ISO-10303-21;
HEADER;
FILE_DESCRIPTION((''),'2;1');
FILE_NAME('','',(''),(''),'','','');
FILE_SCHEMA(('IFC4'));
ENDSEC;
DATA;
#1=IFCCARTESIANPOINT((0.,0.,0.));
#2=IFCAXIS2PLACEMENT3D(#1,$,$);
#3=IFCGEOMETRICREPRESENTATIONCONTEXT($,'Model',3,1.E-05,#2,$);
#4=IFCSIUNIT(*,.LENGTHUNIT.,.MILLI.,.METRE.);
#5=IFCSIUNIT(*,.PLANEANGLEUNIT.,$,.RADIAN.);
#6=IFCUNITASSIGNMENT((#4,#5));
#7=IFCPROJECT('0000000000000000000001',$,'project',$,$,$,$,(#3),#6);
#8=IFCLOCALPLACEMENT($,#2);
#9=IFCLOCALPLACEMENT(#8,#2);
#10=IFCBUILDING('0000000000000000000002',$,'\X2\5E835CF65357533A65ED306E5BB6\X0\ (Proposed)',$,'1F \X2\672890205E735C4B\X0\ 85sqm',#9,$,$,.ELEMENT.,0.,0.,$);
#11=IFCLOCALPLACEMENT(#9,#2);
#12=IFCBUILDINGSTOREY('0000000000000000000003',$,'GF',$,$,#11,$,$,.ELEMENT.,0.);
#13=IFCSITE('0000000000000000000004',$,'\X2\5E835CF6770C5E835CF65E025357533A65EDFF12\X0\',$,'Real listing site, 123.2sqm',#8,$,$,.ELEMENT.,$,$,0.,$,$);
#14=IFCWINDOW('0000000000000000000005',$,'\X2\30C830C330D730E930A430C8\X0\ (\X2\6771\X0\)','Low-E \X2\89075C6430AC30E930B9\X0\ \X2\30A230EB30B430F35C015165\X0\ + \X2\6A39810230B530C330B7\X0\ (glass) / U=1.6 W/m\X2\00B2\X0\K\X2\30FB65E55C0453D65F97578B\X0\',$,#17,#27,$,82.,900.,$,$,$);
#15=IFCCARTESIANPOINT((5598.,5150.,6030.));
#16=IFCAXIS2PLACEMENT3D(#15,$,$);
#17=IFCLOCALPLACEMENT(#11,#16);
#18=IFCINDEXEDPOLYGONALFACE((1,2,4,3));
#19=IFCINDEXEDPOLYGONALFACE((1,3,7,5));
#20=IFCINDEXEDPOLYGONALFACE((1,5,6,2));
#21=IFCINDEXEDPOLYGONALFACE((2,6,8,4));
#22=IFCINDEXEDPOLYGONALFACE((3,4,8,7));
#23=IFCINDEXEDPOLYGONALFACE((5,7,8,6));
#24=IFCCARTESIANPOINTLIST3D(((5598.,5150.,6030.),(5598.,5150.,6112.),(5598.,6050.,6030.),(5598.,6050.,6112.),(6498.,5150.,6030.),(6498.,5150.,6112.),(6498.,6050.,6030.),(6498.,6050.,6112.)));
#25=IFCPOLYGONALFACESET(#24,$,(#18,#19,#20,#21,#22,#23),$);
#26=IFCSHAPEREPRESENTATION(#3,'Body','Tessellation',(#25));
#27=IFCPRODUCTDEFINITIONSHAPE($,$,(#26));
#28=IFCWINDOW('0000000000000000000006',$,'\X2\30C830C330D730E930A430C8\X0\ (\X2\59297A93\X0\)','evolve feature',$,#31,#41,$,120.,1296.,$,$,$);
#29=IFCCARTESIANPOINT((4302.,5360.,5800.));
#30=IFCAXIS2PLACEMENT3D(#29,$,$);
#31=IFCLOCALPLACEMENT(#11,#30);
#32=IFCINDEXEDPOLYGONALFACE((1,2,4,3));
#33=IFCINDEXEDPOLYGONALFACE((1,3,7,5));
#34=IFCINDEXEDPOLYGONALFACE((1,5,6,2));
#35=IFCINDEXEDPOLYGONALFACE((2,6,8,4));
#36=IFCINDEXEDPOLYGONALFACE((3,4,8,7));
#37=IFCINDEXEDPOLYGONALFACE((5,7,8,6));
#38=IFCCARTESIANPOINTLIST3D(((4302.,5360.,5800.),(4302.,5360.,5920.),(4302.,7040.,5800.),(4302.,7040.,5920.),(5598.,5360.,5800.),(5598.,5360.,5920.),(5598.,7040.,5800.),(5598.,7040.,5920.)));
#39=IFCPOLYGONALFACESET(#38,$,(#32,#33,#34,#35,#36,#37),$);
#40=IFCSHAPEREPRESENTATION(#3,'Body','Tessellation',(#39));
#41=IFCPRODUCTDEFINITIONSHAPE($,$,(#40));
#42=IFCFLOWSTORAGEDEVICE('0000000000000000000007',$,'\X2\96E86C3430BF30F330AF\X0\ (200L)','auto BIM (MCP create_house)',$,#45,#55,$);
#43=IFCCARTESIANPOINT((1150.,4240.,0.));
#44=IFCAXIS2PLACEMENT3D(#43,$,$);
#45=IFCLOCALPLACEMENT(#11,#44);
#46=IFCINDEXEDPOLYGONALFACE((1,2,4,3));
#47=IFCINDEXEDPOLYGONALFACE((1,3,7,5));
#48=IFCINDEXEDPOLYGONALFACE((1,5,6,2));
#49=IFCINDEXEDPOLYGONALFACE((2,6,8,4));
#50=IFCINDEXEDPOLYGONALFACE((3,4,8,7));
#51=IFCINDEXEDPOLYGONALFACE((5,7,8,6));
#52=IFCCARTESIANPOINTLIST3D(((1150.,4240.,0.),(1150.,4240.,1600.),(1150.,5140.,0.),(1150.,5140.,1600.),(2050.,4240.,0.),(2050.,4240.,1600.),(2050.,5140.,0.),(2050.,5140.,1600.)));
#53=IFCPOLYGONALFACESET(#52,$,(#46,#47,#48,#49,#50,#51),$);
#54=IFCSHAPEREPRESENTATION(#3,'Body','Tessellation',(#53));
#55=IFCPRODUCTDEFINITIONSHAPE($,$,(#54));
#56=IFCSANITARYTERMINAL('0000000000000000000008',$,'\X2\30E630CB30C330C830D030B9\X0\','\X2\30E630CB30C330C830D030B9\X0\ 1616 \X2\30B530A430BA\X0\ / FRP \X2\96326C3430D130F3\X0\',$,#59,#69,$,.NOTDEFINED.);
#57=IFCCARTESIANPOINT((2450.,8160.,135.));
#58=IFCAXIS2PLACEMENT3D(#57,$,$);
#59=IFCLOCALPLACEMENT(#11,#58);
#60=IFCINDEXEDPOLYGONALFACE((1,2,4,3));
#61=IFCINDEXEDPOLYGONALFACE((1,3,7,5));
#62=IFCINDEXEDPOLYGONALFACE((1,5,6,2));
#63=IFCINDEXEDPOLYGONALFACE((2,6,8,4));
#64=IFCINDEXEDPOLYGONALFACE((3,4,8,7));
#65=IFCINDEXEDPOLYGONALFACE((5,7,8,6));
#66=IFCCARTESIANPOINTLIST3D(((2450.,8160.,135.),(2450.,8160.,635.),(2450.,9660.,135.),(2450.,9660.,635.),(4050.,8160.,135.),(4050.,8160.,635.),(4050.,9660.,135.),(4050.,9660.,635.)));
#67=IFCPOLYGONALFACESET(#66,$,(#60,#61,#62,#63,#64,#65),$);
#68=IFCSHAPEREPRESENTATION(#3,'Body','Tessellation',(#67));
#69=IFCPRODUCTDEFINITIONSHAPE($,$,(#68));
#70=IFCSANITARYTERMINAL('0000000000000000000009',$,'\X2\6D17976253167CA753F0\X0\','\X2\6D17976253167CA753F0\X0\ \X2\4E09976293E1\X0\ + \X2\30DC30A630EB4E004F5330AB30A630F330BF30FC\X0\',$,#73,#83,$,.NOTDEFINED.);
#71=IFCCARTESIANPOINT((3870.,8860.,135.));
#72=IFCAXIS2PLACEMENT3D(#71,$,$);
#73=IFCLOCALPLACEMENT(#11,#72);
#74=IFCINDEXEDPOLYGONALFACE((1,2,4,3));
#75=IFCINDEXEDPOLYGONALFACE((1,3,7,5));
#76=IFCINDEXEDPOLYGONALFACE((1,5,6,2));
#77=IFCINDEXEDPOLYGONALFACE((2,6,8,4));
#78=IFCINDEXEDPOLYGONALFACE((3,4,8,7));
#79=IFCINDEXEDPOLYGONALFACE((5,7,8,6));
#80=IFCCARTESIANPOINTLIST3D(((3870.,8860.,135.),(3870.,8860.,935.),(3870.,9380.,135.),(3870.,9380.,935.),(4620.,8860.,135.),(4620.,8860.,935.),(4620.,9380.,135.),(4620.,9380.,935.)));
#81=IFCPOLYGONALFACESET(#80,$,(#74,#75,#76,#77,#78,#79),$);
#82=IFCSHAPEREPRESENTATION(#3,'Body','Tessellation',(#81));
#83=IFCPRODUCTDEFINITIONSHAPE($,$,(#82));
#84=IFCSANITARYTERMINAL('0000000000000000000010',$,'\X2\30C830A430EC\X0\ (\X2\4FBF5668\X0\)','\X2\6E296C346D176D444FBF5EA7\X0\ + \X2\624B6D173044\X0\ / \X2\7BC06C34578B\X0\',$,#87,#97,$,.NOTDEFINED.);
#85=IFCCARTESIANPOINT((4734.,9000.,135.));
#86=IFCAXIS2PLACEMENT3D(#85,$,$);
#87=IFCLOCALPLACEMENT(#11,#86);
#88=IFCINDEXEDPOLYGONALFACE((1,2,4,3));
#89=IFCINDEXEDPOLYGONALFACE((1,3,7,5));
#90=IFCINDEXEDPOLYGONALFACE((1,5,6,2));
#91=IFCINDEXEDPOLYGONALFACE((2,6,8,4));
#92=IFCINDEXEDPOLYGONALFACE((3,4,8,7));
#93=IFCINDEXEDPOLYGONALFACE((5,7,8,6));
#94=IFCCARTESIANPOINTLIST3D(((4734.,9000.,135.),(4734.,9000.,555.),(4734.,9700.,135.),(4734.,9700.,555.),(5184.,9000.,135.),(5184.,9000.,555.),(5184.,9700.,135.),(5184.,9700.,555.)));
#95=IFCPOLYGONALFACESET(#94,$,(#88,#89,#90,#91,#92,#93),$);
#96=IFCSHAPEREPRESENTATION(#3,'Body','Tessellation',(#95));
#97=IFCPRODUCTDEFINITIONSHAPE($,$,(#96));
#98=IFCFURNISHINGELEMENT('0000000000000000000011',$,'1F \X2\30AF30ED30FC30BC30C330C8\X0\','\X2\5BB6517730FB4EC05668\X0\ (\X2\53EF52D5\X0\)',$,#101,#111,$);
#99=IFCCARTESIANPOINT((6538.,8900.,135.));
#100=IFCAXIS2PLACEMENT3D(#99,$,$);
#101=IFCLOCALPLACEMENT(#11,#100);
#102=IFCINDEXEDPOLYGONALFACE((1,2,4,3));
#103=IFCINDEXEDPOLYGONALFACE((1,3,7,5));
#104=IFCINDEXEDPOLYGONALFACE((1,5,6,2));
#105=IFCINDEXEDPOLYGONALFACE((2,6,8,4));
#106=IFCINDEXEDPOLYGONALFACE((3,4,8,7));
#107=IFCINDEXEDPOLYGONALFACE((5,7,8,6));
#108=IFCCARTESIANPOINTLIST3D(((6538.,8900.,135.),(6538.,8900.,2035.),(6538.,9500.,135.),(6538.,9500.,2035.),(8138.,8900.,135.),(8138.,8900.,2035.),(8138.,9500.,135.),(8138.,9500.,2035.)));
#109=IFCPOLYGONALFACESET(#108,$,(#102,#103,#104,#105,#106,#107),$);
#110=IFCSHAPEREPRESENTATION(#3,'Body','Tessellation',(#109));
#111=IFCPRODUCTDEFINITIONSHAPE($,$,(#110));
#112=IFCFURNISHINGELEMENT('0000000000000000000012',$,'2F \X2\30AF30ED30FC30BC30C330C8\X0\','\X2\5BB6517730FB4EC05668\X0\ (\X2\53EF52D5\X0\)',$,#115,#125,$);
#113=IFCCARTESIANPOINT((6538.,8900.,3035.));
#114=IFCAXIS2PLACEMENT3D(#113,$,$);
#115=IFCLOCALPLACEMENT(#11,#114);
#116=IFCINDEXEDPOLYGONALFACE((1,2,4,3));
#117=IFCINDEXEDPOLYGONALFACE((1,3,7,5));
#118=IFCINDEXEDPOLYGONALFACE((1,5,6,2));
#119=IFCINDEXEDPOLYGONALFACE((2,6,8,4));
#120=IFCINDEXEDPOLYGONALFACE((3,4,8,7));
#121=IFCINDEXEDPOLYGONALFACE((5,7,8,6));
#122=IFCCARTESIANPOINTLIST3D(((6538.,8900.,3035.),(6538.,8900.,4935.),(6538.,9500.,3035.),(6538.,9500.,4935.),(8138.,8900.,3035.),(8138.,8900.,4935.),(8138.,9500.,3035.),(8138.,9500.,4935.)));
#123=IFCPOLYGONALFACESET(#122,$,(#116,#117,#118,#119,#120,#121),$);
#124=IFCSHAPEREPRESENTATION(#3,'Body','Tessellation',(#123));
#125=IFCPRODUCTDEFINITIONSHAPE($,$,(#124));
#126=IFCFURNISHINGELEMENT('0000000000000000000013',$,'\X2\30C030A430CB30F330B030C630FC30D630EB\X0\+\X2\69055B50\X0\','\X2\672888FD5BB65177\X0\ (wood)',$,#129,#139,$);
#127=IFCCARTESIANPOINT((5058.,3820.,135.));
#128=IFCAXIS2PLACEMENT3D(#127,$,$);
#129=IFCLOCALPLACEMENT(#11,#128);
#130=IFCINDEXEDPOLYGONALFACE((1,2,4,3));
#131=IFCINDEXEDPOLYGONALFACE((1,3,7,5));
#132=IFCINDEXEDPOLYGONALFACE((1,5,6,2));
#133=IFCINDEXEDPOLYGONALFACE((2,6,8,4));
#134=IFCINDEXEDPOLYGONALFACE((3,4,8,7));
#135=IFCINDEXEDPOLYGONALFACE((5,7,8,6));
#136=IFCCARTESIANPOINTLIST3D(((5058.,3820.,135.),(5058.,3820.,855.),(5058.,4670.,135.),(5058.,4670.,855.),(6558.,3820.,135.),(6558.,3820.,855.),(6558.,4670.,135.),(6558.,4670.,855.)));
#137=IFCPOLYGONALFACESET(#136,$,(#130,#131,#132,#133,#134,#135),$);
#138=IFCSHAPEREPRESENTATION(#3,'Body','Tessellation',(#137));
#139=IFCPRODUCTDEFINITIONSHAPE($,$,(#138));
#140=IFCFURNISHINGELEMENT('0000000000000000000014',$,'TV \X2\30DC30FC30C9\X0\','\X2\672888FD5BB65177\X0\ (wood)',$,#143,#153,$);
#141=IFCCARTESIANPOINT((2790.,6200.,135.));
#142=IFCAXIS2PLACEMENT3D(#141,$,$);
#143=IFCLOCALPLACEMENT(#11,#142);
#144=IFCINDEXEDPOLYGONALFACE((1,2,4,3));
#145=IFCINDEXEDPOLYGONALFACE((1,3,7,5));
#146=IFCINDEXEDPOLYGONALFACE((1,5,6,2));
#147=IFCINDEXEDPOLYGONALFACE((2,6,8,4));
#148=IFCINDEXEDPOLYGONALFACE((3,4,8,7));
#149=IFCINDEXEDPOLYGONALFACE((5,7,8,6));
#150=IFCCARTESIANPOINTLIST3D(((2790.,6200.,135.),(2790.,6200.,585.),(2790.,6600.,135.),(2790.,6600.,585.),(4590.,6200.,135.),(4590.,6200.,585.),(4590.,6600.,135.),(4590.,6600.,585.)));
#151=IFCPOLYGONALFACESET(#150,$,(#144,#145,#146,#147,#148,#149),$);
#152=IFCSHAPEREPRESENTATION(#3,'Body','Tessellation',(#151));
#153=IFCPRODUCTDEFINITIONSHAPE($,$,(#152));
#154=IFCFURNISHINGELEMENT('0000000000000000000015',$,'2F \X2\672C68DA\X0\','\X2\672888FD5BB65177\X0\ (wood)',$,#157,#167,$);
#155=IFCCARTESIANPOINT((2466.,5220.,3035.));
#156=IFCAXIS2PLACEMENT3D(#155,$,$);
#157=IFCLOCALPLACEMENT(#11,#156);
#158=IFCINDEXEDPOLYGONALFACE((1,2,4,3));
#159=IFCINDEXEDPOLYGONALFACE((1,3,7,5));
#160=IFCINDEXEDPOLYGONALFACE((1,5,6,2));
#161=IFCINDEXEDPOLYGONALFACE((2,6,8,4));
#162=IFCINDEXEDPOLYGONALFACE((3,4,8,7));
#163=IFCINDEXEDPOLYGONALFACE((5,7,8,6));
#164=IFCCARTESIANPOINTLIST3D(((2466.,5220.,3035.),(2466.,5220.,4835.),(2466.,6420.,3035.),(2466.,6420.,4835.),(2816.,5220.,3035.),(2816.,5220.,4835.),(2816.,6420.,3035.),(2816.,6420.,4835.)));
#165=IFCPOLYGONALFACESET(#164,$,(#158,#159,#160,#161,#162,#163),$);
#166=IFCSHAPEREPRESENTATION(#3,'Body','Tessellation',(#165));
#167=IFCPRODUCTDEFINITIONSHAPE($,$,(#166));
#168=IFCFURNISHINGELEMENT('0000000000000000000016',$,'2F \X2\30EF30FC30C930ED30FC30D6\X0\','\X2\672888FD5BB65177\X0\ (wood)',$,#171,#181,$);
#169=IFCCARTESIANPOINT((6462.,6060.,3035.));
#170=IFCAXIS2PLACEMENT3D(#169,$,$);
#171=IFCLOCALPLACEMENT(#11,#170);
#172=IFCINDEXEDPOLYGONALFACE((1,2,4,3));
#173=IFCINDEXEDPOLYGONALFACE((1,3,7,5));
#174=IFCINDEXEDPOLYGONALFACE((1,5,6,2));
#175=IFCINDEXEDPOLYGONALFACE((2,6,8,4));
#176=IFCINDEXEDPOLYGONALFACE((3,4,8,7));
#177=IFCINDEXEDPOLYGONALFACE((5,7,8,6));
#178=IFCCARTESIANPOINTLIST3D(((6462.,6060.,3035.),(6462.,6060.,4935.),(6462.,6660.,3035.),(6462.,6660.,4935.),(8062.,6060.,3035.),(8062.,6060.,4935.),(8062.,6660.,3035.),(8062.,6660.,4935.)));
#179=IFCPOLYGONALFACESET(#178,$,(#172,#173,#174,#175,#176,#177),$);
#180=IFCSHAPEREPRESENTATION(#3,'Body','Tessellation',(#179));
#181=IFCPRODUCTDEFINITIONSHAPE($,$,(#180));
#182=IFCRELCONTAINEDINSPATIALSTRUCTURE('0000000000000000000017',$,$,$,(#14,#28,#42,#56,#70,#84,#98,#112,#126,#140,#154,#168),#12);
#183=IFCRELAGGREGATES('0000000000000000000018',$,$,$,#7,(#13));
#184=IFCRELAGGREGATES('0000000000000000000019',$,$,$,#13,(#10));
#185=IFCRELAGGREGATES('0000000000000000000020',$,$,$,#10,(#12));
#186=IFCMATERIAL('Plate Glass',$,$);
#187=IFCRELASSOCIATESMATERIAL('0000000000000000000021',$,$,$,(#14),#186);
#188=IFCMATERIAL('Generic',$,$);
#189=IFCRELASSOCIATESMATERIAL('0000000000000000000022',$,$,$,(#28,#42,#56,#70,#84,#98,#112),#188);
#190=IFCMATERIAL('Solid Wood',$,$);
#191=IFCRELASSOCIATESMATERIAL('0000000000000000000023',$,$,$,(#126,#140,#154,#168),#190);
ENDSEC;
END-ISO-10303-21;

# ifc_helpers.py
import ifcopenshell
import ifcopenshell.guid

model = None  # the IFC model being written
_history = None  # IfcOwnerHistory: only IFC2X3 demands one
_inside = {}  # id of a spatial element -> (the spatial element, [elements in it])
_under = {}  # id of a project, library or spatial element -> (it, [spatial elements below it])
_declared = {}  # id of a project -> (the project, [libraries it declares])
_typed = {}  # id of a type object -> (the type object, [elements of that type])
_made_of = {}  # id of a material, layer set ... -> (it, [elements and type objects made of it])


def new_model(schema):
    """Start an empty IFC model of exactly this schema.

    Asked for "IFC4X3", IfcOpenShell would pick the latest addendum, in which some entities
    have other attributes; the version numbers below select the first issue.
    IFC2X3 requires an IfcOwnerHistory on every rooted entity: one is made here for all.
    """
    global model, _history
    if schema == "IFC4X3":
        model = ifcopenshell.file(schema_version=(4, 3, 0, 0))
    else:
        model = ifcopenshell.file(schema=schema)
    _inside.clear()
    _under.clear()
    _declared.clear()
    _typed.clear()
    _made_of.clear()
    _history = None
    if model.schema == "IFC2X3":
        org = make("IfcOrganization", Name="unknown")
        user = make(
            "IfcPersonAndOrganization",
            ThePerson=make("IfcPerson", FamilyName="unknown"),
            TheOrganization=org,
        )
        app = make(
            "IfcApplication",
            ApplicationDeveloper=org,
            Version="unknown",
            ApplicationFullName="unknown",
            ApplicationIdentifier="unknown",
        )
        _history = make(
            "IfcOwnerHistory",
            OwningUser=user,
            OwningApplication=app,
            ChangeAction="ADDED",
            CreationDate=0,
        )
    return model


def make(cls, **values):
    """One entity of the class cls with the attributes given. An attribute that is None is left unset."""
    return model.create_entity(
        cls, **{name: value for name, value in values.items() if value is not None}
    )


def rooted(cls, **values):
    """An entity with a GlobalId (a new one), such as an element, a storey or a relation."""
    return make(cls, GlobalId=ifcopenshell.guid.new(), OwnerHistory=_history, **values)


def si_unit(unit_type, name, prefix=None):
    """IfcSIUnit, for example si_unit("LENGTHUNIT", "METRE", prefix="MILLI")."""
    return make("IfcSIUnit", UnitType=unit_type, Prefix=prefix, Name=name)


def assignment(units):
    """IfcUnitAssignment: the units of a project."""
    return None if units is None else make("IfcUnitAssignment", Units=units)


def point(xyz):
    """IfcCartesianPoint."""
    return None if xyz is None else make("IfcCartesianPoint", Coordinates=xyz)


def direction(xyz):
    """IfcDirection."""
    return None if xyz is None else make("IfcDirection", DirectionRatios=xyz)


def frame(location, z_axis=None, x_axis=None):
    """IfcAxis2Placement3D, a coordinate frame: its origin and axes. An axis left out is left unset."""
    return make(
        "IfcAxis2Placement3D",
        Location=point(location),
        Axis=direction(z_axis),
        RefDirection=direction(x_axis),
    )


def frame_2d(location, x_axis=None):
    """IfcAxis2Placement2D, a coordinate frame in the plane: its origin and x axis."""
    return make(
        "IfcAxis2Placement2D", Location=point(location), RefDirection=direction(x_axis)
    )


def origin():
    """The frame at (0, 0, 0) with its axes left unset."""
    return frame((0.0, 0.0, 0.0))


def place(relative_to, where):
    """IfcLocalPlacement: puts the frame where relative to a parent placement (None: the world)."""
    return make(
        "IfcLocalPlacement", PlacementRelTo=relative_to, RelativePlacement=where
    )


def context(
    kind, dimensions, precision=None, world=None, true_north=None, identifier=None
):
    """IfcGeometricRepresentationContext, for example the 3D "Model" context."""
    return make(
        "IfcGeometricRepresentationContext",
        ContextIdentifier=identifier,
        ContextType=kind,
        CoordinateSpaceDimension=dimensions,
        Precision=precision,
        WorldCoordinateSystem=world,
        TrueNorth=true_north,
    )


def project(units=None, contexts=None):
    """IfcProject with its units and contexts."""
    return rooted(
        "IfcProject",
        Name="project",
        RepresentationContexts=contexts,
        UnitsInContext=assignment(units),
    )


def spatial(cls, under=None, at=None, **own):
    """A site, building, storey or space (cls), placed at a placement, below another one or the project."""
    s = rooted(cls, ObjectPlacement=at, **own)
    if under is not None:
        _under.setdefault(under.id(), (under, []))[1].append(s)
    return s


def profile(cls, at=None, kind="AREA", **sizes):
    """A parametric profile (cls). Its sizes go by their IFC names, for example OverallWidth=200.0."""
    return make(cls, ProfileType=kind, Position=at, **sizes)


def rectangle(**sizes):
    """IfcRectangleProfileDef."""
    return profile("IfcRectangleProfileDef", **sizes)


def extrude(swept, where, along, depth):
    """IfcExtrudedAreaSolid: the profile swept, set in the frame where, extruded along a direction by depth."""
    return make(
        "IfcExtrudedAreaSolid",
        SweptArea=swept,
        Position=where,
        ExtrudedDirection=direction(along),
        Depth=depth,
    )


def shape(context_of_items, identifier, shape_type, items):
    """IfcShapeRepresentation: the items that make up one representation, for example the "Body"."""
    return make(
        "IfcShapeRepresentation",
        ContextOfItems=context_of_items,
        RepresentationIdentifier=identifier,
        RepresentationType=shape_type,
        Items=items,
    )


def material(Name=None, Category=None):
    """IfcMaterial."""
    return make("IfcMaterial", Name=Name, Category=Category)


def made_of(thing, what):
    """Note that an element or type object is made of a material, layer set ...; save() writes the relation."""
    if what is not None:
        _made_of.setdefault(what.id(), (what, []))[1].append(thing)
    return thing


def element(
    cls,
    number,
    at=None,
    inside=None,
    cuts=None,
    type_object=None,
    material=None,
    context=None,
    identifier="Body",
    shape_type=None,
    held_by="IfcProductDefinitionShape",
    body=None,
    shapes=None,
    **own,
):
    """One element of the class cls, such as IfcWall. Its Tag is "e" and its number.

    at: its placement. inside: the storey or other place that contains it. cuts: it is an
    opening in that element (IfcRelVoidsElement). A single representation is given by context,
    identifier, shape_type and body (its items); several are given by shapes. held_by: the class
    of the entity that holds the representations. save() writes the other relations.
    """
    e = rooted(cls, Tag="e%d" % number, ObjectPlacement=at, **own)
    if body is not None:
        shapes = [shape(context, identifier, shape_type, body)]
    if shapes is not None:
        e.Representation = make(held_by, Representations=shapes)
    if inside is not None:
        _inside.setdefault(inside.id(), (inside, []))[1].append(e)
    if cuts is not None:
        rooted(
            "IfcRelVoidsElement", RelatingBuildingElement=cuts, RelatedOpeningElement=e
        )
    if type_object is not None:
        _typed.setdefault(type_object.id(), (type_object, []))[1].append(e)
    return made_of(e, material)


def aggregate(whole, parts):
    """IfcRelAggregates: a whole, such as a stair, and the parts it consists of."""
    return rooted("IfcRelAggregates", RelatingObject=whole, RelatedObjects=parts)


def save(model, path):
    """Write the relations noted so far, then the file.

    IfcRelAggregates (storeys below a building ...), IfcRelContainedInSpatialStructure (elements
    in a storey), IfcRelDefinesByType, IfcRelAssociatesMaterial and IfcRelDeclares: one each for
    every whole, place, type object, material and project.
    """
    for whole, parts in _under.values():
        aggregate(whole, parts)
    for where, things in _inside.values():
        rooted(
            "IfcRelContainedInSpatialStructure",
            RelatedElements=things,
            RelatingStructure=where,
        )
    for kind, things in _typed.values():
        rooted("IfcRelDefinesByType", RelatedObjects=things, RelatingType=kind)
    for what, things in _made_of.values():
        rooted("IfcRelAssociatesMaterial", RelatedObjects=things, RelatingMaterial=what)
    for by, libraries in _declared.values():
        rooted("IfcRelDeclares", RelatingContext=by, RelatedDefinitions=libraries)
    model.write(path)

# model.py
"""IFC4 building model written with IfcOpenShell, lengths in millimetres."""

from ifc_helpers import new_model, si_unit, frame, frame_2d, origin, place, context, project, spatial, rectangle, extrude, material, element, save


model = new_model("IFC4")

# Units and contexts
model_context = context("Model", 3, precision=1e-05, world=origin())
ifc_project = project(units=[si_unit("LENGTHUNIT", "METRE", prefix="MILLI"), si_unit("PLANEANGLEUNIT", "RADIAN")], contexts=[model_context])

# Site, building, storey
site_placement = place(None, origin())
site = spatial("IfcSite", under=ifc_project, at=site_placement, Name="広島県広島市南区旭２", ObjectType="Real listing site, 123.2sqm", CompositionType="ELEMENT", RefElevation=0.0)
building_placement = place(site_placement, origin())
building = spatial("IfcBuilding", under=site, at=building_placement, Name="広島南区旭の家 (Proposed)", ObjectType="1F 木造平屋 85sqm", CompositionType="ELEMENT", ElevationOfRefHeight=0.0, ElevationOfTerrain=0.0)
storey_placement = place(building_placement, origin())
storey = spatial("IfcBuildingStorey", under=building, at=storey_placement, Name="GF", CompositionType="ELEMENT", Elevation=0.0)

# Shared definitions
ifc_material_1 = material(Name="Solid Wood")
ifc_material_2 = material(Name="Plate Glass")

# Windows
window_1_placement = place(storey_placement, frame((5598.0, 5150.0, 6030.0)))
element("IfcWindow", 1, at=window_1_placement, inside=storey, material=ifc_material_2, Name="トップライト (東)", Description="Low-E 複層ガラス アルゴン封入 + 樹脂サッシ (glass) / U=1.6 W/m²K・日射取得型", OverallHeight=82.0, OverallWidth=900.0, context=model_context, shape_type="SweptSolid", body=[
    extrude(rectangle(XDim=900.0, YDim=900.0, at=frame_2d((450.0, 450.0))), frame((5598.0, 5150.0, 6030.0)), (0.0, 0.0, 1.0), 82.0),
])
ifc_material_3 = material(Name="Generic")
window_2_placement = place(storey_placement, frame((4302.0, 5360.0, 5800.0)))
element("IfcWindow", 2, at=window_2_placement, inside=storey, material=ifc_material_3, Name="トップライト (天窓)", Description="evolve feature", OverallHeight=120.0, OverallWidth=1296.0, context=model_context, shape_type="SweptSolid", body=[
    extrude(rectangle(XDim=1296.0, YDim=1680.0, at=frame_2d((648.0, 840.0))), frame((4302.0, 5360.0, 5800.0)), (0.0, 0.0, 1.0), 120.0),
])

# Flow storage device
flow_storage_device_placement = place(storey_placement, frame((1150.0, 4240.0, 0.0)))
element("IfcFlowStorageDevice", 3, at=flow_storage_device_placement, inside=storey, material=ifc_material_3, Name="雨水タンク (200L)", Description="auto BIM (MCP create_house)", context=model_context, shape_type="SweptSolid", body=[
    extrude(rectangle(XDim=900.0, YDim=900.0, at=frame_2d((450.0, 450.0))), frame((1150.0, 4240.0, 0.0)), (0.0, 0.0, 1.0), 1600.0),
])

# Sanitary terminals
sanitary_terminal_1_placement = place(storey_placement, frame((2450.0, 8160.0, 135.0)))
element("IfcSanitaryTerminal", 4, at=sanitary_terminal_1_placement, inside=storey, material=ifc_material_3, Name="ユニットバス", Description="ユニットバス 1616 サイズ / FRP 防水パン", PredefinedType="NOTDEFINED", context=model_context, shape_type="SweptSolid", body=[
    extrude(rectangle(XDim=1600.0, YDim=1500.0, at=frame_2d((800.0, 750.0))), frame((2450.0, 8160.0, 135.0)), (0.0, 0.0, 1.0), 500.0),
])
sanitary_terminal_2_placement = place(storey_placement, frame((3870.0, 8860.0, 135.0)))
element("IfcSanitaryTerminal", 5, at=sanitary_terminal_2_placement, inside=storey, material=ifc_material_3, Name="洗面化粧台", Description="洗面化粧台 三面鏡 + ボウル一体カウンター", PredefinedType="NOTDEFINED", context=model_context, shape_type="SweptSolid", body=[
    extrude(rectangle(XDim=750.0, YDim=520.0, at=frame_2d((375.0, 260.0))), frame((3870.0, 8860.0, 135.0)), (0.0, 0.0, 1.0), 800.0),
])
sanitary_terminal_3_placement = place(storey_placement, frame((4734.0, 9000.0, 135.0)))
element("IfcSanitaryTerminal", 6, at=sanitary_terminal_3_placement, inside=storey, material=ifc_material_3, Name="トイレ (便器)", Description="温水洗浄便座 + 手洗い / 節水型", PredefinedType="NOTDEFINED", context=model_context, shape_type="SweptSolid", body=[
    extrude(rectangle(XDim=450.0, YDim=700.0, at=frame_2d((225.0, 350.0))), frame((4734.0, 9000.0, 135.0)), (0.0, 0.0, 1.0), 420.0),
])

# Furnishing elements
furnishing_1_placement = place(storey_placement, frame((6538.0, 8900.0, 135.0)))
element("IfcFurnishingElement", 7, at=furnishing_1_placement, inside=storey, material=ifc_material_3, Name="1F クローゼット", Description="家具・什器 (可動)", context=model_context, shape_type="SweptSolid", body=[
    extrude(rectangle(XDim=1600.0, YDim=600.0, at=frame_2d((800.0, 300.0))), frame((6538.0, 8900.0, 135.0)), (0.0, 0.0, 1.0), 1900.0),
])
furnishing_2_placement = place(storey_placement, frame((6538.0, 8900.0, 3035.0)))
element("IfcFurnishingElement", 8, at=furnishing_2_placement, inside=storey, material=ifc_material_3, Name="2F クローゼット", Description="家具・什器 (可動)", context=model_context, shape_type="SweptSolid", body=[
    extrude(rectangle(XDim=1600.0, YDim=600.0, at=frame_2d((800.0, 300.0))), frame((6538.0, 8900.0, 3035.0)), (0.0, 0.0, 1.0), 1900.0),
])
furnishing_3_placement = place(storey_placement, frame((5058.0, 3820.0, 135.0)))
element("IfcFurnishingElement", 9, at=furnishing_3_placement, inside=storey, material=ifc_material_1, Name="ダイニングテーブル+椅子", Description="木製家具 (wood)", context=model_context, shape_type="SweptSolid", body=[
    extrude(rectangle(XDim=1500.0, YDim=850.0, at=frame_2d((750.0, 425.0))), frame((5058.0, 3820.0, 135.0)), (0.0, 0.0, 1.0), 720.0),
])
furnishing_4_placement = place(storey_placement, frame((2790.0, 6200.0, 135.0)))
element("IfcFurnishingElement", 10, at=furnishing_4_placement, inside=storey, material=ifc_material_1, Name="TV ボード", Description="木製家具 (wood)", context=model_context, shape_type="SweptSolid", body=[
    extrude(rectangle(XDim=1800.0, YDim=400.0, at=frame_2d((900.0, 200.0))), frame((2790.0, 6200.0, 135.0)), (0.0, 0.0, 1.0), 450.0),
])
furnishing_5_placement = place(storey_placement, frame((2466.0, 5220.0, 3035.0)))
element("IfcFurnishingElement", 11, at=furnishing_5_placement, inside=storey, material=ifc_material_1, Name="2F 本棚", Description="木製家具 (wood)", context=model_context, shape_type="SweptSolid", body=[
    extrude(rectangle(XDim=350.0, YDim=1200.0, at=frame_2d((175.0, 600.0))), frame((2466.0, 5220.0, 3035.0)), (0.0, 0.0, 1.0), 1800.0),
])
furnishing_6_placement = place(storey_placement, frame((6462.0, 6060.0, 3035.0)))
element("IfcFurnishingElement", 12, at=furnishing_6_placement, inside=storey, material=ifc_material_1, Name="2F ワードローブ", Description="木製家具 (wood)", context=model_context, shape_type="SweptSolid", body=[
    extrude(rectangle(XDim=1600.0, YDim=600.0, at=frame_2d((800.0, 300.0))), frame((6462.0, 6060.0, 3035.0)), (0.0, 0.0, 1.0), 1900.0),
])

save(model, "model.ifc")
